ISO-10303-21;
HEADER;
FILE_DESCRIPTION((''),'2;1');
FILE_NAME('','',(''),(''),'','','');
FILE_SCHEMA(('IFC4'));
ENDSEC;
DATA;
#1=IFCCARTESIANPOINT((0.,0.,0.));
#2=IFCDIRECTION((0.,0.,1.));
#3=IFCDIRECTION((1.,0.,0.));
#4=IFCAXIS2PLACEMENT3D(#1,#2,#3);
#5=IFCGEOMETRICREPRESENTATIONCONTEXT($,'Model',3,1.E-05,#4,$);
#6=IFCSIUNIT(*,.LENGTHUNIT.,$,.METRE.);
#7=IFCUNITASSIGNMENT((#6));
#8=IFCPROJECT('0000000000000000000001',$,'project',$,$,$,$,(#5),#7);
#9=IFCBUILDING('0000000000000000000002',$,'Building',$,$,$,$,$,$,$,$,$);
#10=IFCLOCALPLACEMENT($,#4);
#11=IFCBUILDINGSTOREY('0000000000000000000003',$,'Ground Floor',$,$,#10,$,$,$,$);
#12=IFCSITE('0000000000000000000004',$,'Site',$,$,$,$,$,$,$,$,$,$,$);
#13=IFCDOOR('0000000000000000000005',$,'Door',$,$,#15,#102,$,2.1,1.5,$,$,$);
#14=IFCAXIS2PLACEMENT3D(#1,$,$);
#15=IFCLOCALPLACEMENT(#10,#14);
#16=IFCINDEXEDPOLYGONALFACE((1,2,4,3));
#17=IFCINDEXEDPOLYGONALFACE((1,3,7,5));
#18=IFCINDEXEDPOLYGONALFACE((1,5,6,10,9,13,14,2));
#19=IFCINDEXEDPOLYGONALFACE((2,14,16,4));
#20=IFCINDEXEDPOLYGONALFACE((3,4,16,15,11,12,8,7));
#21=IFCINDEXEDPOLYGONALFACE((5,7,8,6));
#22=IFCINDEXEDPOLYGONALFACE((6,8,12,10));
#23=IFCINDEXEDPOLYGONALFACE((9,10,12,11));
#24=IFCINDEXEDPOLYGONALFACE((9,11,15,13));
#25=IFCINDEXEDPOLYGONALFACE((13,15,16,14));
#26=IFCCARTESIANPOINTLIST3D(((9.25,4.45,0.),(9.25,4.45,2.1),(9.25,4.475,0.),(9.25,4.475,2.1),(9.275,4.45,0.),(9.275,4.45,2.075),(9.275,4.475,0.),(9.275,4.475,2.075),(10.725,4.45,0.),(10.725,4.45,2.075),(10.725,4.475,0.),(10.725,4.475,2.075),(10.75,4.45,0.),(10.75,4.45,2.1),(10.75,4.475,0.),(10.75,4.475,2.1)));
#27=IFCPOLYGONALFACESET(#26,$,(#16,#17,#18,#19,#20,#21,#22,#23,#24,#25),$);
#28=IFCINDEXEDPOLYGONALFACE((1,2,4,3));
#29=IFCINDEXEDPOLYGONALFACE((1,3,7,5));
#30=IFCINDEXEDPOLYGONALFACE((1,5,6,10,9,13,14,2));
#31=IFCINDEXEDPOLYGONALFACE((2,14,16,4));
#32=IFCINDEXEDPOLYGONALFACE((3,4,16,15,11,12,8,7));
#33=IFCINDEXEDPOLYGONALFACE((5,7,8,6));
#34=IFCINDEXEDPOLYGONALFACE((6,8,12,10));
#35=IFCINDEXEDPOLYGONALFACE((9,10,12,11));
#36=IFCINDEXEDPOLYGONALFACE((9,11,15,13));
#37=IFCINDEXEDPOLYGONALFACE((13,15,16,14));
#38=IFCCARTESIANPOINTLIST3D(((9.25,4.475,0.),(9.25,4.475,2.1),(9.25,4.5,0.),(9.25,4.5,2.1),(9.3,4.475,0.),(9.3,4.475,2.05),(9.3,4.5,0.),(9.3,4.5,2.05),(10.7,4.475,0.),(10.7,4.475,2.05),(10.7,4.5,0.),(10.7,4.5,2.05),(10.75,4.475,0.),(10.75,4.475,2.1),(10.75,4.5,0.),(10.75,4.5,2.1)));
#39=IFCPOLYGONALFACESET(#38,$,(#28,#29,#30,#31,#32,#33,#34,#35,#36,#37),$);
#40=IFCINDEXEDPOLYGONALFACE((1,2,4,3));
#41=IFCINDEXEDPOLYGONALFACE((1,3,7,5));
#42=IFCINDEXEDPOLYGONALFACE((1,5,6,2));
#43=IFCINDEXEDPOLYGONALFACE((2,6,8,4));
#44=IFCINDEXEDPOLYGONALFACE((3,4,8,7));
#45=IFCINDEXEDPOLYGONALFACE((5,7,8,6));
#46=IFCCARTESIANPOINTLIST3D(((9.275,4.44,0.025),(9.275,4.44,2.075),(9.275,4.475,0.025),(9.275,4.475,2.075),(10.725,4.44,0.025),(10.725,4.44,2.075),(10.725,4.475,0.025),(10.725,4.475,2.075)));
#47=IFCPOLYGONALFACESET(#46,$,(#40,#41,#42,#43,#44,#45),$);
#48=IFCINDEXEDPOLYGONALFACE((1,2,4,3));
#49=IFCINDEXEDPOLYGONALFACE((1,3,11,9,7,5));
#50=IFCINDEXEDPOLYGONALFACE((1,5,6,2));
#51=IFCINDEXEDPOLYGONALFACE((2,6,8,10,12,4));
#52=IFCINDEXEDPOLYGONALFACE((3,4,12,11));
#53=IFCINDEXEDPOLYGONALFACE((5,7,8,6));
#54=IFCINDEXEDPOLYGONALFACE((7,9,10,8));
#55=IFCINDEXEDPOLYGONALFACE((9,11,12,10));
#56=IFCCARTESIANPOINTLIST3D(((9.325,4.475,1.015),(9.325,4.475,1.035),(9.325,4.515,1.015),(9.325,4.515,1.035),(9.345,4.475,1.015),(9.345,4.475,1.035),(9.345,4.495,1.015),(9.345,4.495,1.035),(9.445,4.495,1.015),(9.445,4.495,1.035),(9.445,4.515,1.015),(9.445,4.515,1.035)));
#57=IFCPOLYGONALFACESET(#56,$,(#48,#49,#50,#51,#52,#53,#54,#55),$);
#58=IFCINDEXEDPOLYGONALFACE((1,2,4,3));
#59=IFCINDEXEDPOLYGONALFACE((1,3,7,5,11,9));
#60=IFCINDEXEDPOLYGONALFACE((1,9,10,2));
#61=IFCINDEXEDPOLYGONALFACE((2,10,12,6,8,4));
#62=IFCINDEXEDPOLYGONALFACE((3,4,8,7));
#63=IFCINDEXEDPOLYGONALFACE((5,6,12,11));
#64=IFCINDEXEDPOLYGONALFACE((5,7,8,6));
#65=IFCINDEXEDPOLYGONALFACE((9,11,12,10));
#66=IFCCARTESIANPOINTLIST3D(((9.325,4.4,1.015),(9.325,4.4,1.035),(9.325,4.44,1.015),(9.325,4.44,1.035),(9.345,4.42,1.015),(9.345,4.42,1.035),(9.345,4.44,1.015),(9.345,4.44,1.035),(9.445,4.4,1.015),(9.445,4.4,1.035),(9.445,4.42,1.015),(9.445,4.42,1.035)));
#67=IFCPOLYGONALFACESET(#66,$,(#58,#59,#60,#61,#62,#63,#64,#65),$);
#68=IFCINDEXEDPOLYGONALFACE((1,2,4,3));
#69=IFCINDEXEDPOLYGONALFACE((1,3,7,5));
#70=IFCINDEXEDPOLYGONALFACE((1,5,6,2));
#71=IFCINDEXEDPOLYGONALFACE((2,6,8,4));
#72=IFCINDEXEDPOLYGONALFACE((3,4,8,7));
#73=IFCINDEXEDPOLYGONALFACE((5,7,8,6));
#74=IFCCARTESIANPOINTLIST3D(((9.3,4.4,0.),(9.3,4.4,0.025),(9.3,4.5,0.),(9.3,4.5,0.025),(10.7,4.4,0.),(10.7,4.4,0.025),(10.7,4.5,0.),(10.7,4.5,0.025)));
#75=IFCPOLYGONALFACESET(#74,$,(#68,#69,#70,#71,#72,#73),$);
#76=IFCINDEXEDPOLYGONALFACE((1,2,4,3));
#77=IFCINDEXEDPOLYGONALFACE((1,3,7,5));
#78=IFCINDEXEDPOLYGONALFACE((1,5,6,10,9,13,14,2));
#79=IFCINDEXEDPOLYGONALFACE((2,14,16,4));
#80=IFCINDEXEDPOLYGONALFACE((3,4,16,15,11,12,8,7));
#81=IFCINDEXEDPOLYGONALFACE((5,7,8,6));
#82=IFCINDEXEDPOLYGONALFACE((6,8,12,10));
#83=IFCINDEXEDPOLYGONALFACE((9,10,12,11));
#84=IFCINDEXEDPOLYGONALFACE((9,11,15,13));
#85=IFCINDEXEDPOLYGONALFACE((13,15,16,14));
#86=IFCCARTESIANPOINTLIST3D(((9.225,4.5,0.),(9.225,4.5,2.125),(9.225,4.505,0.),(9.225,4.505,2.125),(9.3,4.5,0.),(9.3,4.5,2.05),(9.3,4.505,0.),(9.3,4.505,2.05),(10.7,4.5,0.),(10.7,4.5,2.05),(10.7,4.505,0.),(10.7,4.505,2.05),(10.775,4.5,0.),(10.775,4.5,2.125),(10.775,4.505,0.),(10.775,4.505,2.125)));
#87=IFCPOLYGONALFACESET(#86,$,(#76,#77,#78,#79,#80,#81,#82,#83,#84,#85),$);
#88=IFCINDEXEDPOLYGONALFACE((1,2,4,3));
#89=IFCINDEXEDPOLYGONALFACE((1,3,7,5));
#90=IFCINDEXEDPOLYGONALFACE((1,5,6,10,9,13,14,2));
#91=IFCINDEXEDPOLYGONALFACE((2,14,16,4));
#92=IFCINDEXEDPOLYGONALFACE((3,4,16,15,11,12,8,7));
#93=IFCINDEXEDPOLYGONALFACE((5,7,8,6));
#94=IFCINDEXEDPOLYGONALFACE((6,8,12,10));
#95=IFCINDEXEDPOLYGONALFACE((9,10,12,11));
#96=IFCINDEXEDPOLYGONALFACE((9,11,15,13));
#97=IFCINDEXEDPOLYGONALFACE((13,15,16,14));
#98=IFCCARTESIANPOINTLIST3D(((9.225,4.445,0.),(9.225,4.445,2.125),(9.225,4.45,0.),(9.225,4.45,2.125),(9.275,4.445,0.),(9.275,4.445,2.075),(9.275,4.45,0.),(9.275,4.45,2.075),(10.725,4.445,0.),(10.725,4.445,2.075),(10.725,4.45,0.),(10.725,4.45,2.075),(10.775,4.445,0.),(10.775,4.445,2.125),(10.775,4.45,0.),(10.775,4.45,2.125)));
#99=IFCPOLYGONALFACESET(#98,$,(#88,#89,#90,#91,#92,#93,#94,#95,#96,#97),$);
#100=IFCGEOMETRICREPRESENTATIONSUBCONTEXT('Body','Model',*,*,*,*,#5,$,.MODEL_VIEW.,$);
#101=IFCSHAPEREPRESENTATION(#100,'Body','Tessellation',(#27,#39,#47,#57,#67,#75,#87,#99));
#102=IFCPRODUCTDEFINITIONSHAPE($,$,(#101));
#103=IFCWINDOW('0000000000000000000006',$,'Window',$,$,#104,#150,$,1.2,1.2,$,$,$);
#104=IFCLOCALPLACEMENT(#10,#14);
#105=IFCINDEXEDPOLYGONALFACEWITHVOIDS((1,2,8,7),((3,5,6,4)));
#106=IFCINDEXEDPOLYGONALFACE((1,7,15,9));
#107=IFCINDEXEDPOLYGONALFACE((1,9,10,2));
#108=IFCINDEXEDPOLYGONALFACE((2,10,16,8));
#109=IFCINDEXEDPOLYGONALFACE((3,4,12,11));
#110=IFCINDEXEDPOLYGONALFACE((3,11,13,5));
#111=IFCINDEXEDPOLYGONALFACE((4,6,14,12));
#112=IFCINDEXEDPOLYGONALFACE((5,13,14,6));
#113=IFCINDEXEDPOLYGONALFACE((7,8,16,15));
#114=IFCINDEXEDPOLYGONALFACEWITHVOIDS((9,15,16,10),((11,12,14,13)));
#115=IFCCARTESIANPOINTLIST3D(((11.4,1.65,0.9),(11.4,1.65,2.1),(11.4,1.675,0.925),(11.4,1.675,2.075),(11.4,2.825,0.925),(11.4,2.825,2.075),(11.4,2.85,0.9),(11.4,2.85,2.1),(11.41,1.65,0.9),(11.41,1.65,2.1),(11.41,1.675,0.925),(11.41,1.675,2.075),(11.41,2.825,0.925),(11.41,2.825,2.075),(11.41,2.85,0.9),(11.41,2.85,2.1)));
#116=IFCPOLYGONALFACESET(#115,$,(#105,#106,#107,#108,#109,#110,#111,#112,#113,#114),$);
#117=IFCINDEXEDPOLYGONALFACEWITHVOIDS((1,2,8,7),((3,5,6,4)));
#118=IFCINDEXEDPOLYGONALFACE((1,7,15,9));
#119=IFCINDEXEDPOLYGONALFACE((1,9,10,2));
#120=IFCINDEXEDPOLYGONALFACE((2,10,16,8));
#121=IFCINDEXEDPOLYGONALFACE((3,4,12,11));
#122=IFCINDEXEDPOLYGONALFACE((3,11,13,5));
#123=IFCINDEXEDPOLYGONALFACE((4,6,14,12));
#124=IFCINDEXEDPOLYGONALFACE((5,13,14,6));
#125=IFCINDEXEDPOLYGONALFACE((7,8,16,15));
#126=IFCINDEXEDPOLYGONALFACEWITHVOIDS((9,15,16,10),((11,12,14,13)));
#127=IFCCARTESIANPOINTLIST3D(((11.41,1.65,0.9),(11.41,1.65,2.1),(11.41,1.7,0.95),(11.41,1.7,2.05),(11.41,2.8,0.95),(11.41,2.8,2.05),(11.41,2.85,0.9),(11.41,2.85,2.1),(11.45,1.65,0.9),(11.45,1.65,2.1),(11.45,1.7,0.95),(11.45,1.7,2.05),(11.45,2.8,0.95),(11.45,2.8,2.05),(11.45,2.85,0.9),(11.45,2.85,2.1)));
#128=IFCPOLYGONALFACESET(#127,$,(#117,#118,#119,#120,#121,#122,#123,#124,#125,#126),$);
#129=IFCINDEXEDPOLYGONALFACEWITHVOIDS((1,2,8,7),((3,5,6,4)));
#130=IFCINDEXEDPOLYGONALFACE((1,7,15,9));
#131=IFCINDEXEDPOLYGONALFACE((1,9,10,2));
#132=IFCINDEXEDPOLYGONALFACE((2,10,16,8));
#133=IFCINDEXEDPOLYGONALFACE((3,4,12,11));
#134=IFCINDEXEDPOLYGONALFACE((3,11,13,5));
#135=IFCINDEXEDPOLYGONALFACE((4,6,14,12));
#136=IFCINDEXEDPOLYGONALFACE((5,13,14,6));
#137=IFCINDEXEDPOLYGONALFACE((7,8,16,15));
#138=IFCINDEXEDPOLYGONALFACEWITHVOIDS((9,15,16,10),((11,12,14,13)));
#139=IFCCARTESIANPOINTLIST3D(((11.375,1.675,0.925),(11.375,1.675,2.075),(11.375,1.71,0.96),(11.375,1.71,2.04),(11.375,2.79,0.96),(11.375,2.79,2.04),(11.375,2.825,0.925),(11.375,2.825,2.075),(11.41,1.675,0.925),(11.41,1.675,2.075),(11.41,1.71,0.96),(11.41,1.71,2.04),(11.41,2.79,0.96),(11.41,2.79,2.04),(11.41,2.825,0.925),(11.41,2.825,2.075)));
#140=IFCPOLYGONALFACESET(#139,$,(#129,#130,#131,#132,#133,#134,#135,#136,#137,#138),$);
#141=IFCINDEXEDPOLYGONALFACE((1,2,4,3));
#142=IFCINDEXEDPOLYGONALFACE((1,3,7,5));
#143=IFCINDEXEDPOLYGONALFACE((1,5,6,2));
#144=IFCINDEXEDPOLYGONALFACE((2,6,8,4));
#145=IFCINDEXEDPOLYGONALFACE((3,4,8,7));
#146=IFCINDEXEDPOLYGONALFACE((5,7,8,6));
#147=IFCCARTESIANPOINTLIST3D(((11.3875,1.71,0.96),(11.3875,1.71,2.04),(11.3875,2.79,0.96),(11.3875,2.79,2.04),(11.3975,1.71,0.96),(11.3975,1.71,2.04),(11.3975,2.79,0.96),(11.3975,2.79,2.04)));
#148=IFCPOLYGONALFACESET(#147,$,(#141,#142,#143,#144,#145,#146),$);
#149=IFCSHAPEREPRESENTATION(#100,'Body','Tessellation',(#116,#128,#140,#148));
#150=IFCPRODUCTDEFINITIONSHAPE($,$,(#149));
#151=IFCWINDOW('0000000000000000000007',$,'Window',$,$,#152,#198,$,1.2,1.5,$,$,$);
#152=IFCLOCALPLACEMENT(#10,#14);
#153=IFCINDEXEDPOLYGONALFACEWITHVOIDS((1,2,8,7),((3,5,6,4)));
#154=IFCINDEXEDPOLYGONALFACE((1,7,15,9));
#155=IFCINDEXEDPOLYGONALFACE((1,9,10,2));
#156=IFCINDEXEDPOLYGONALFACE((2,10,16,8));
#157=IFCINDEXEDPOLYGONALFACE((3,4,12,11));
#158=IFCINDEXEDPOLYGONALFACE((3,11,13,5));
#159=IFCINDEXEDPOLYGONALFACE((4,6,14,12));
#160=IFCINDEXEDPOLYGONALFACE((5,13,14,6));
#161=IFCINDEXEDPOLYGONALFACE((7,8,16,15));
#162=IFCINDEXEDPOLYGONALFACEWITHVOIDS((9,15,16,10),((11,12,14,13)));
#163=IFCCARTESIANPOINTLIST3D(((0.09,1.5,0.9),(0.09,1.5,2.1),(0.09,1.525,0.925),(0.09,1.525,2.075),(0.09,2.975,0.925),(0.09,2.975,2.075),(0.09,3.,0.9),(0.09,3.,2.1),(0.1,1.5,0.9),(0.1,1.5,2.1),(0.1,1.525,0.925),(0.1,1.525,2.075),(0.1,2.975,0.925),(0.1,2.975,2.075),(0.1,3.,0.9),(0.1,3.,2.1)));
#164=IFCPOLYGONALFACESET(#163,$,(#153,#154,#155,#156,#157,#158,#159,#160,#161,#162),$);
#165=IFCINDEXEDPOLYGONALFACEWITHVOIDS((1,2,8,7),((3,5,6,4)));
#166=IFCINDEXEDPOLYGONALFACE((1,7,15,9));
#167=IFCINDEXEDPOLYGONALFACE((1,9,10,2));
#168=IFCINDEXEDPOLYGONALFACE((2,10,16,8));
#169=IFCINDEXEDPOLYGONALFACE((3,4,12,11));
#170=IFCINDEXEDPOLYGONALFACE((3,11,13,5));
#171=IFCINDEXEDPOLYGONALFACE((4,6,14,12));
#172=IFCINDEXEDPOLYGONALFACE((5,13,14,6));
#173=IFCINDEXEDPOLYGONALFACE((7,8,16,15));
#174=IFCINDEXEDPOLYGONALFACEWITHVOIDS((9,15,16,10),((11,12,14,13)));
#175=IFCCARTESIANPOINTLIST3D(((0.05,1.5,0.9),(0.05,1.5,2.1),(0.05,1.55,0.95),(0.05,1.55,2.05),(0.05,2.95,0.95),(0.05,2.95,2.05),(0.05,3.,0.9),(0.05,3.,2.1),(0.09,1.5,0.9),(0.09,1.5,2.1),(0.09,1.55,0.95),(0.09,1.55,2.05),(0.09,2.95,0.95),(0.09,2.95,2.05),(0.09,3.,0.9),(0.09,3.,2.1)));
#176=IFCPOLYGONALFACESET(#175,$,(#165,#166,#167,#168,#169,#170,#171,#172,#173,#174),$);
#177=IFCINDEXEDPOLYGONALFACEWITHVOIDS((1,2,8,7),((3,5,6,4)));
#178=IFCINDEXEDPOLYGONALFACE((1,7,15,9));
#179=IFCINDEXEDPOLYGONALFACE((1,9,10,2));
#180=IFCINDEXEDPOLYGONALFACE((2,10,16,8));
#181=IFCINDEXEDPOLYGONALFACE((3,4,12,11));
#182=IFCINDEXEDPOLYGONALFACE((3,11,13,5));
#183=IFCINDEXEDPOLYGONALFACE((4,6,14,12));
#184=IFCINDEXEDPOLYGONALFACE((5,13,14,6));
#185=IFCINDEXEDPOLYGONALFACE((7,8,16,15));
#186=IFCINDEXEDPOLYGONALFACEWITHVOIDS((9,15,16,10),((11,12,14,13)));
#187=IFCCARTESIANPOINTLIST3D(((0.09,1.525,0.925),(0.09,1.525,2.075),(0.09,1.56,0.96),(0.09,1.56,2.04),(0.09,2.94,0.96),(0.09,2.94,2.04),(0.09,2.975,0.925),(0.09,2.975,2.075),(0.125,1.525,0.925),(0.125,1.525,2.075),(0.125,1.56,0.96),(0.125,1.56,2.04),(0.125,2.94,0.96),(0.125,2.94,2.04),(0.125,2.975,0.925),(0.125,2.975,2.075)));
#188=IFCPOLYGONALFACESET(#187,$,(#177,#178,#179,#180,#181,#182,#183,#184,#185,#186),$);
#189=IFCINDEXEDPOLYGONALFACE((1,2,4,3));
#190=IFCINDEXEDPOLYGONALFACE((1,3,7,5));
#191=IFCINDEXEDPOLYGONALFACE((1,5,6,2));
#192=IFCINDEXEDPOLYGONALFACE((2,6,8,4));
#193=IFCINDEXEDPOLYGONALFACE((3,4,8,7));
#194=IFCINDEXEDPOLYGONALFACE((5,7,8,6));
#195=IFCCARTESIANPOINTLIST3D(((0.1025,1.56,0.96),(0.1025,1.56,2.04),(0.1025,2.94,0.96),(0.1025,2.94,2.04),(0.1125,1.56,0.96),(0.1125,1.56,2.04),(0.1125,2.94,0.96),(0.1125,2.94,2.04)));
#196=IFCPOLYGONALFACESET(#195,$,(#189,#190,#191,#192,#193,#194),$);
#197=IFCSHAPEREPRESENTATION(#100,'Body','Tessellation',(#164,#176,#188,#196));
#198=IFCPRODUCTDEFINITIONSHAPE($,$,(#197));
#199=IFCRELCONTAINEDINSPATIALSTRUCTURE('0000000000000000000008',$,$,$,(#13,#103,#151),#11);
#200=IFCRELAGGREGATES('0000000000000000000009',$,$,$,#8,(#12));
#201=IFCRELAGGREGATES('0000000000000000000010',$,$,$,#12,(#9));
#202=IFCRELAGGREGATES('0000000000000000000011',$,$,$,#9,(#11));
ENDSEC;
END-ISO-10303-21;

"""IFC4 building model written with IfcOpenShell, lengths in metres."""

from ifc_helpers import new_model, si_unit, frame, origin_with_axes, place, context, subcontext, project, spatial, line, indexed_curve, outline, extrude, element, save


model = new_model("IFC4")

# Units and contexts
model_context = context("Model", 3, precision=1e-05, world=origin_with_axes())
body_context = subcontext(model_context, "Body", "Model", "MODEL_VIEW")
ifc_project = project(units=[si_unit("LENGTHUNIT", "METRE")], contexts=[model_context])

# Site, building, storey
site = spatial("IfcSite", under=ifc_project, Name="Site")
building = spatial("IfcBuilding", under=site, Name="Building")
storey_placement = place(None, origin_with_axes())
storey = spatial("IfcBuildingStorey", under=building, at=storey_placement, Name="Ground Floor")

# Door
door_1_placement = place(storey_placement, frame((10.75, 4.5, 0.0), z_axis=(0.0, 0.0, 1.0), x_axis=(-1.0, 0.0, 0.0)))
element("IfcDoor", 1, at=door_1_placement, inside=storey, Name="Door", OverallHeight=2.1, OverallWidth=1.5, context=body_context, shape_type="SweptSolid", body=[
    extrude(outline(indexed_curve([(0.0, 0.0), (0.0, 2.1), (1.5, 2.1), (1.5, 0.0), (1.475, 0.0), (1.475, 2.075), (0.025, 2.075), (0.025, 0.0)], segments=[line(1, 2, 3, 4, 5, 6, 7, 8, 1)])), frame((0.0, 0.025, 0.0), z_axis=(0.0, -1.0, 0.0), x_axis=(1.0, 0.0, 0.0)), (0.0, 0.0, -1.0), 0.025),
    extrude(outline(indexed_curve([(0.0, 0.0), (0.0, 2.1), (1.5, 2.1), (1.5, 0.0), (1.45, 0.0), (1.45, 2.05), (0.05, 2.05), (0.05, 0.0)], segments=[line(1, 2, 3, 4, 5, 6, 7, 8, 1)])), frame((0.0, 0.0, 0.0), z_axis=(0.0, -1.0, 0.0), x_axis=(1.0, 0.0, 0.0)), (0.0, 0.0, -1.0), 0.025),
    extrude(outline(indexed_curve([(0.0, 0.0), (1.45, 0.0), (1.45, 0.035), (0.0, 0.035)], segments=[line(1, 2, 3, 4, 1)])), frame((0.025, 0.025, 0.025), z_axis=(0.0, 0.0, 1.0), x_axis=(1.0, 0.0, 0.0)), (0.0, 0.0, 1.0), 2.05),
    extrude(outline(indexed_curve([(0.0, 0.0), (0.0, -0.04), (-0.12, -0.04), (-0.12, -0.02), (-0.02, -0.02), (-0.02, 0.0)], segments=[line(1, 2, 3, 4, 5, 6, 1)])), frame((1.425, 0.025, 1.015), z_axis=(0.0, 0.0, 1.0), x_axis=(1.0, 0.0, 0.0)), (0.0, 0.0, 1.0), 0.02),
    extrude(outline(indexed_curve([(0.0, 0.0), (0.0, 0.04), (-0.12, 0.04), (-0.12, 0.02), (-0.02, 0.02), (-0.02, 0.0)], segments=[line(1, 2, 3, 4, 5, 6, 1)])), frame((1.425, 0.06, 1.015), z_axis=(0.0, 0.0, 1.0), x_axis=(1.0, 0.0, 0.0)), (0.0, 0.0, 1.0), 0.02),
    extrude(outline(indexed_curve([(0.0, 0.0), (1.4, 0.0), (1.4, 0.1), (0.0, 0.1)], segments=[line(1, 2, 3, 4, 1)])), frame((0.05, 0.0, 0.0), z_axis=(0.0, 0.0, 1.0), x_axis=(1.0, 0.0, 0.0)), (0.0, 0.0, 1.0), 0.025),
    extrude(outline(indexed_curve([(0.0, 0.0), (0.0, 2.125), (1.55, 2.125), (1.55, 0.0), (1.475, 0.0), (1.475, 2.05), (0.075, 2.05), (0.075, 0.0)], segments=[line(1, 2, 3, 4, 5, 6, 7, 8, 1)])), frame((-0.025, -0.005, 0.0), z_axis=(0.0, -1.0, 0.0), x_axis=(1.0, 0.0, 0.0)), (0.0, 0.0, -1.0), 0.005),
    extrude(outline(indexed_curve([(0.0, 0.0), (0.0, 2.125), (1.55, 2.125), (1.55, 0.0), (1.5, 0.0), (1.5, 2.075), (0.05, 2.075), (0.05, 0.0)], segments=[line(1, 2, 3, 4, 5, 6, 7, 8, 1)])), frame((-0.025, 0.05, 0.0), z_axis=(0.0, -1.0, 0.0), x_axis=(1.0, 0.0, 0.0)), (0.0, 0.0, -1.0), 0.005),
])

# Windows
window_1_placement = place(storey_placement, frame((11.5, 1.65, 0.9), z_axis=(0.0, 0.0, 1.0), x_axis=(0.0, 1.0, 0.0)))
element("IfcWindow", 2, at=window_1_placement, inside=storey, Name="Window", OverallHeight=1.2, OverallWidth=1.2, context=body_context, shape_type="SweptSolid", body=[
    extrude(outline(indexed_curve([(0.0, 0.0), (1.2, 0.0), (1.2, 1.2), (0.0, 1.2)], segments=[line(1, 2, 3, 4, 1)]), holes=[indexed_curve([(0.025, 0.025), (1.175, 0.025), (1.175, 1.175), (0.025, 1.175)], segments=[line(1, 2, 3, 4, 1)])]), frame((0.0, 0.09, 0.0), z_axis=(0.0, -1.0, 0.0), x_axis=(1.0, 0.0, 0.0)), (0.0, 0.0, -1.0), 0.01),
    extrude(outline(indexed_curve([(0.0, 0.0), (1.2, 0.0), (1.2, 1.2), (0.0, 1.2)], segments=[line(1, 2, 3, 4, 1)]), holes=[indexed_curve([(0.05, 0.05), (1.15, 0.05), (1.15, 1.15), (0.05, 1.15)], segments=[line(1, 2, 3, 4, 1)])]), frame((0.0, 0.05, 0.0), z_axis=(0.0, -1.0, 0.0), x_axis=(1.0, 0.0, 0.0)), (0.0, 0.0, -1.0), 0.04),
    extrude(outline(indexed_curve([(0.0, 0.0), (1.15, 0.0), (1.15, 1.15), (0.0, 1.15)], segments=[line(1, 2, 3, 4, 1)]), holes=[indexed_curve([(0.035, 0.035), (1.115, 0.035), (1.115, 1.115), (0.035, 1.115)], segments=[line(1, 2, 3, 4, 1)])]), frame((0.025, 0.09, 0.025), z_axis=(0.0, -1.0, 0.0), x_axis=(1.0, 0.0, 0.0)), (0.0, 0.0, -1.0), 0.035),
    extrude(outline(indexed_curve([(0.035, 0.035), (1.115, 0.035), (1.115, 1.115), (0.035, 1.115)], segments=[line(1, 2, 3, 4, 1)])), frame((0.025, 0.1025, 0.025), z_axis=(0.0, -1.0, 0.0), x_axis=(1.0, 0.0, 0.0)), (0.0, 0.0, -1.0), 0.01),
])
for number, where, z_axis, x_axis, name in (
    (3, (0.0, 3.0, 0.9), (0.0, 0.0, 1.0), (0.0, -1.0, 0.0), "Window"),
):
    element("IfcWindow", number, at=place(storey_placement, frame(where, z_axis=z_axis, x_axis=x_axis)), inside=storey, Name=name, OverallHeight=1.2, OverallWidth=1.5, context=body_context, shape_type="SweptSolid", body=[
        extrude(outline(indexed_curve([(0.0, 0.0), (1.5, 0.0), (1.5, 1.2), (0.0, 1.2)], segments=[line(1, 2, 3, 4, 1)]), holes=[indexed_curve([(0.025, 0.025), (1.475, 0.025), (1.475, 1.175), (0.025, 1.175)], segments=[line(1, 2, 3, 4, 1)])]), frame((0.0, 0.09, 0.0), z_axis=(0.0, -1.0, 0.0), x_axis=(1.0, 0.0, 0.0)), (0.0, 0.0, -1.0), 0.01),
        extrude(outline(indexed_curve([(0.0, 0.0), (1.5, 0.0), (1.5, 1.2), (0.0, 1.2)], segments=[line(1, 2, 3, 4, 1)]), holes=[indexed_curve([(0.05, 0.05), (1.45, 0.05), (1.45, 1.15), (0.05, 1.15)], segments=[line(1, 2, 3, 4, 1)])]), frame((0.0, 0.05, 0.0), z_axis=(0.0, -1.0, 0.0), x_axis=(1.0, 0.0, 0.0)), (0.0, 0.0, -1.0), 0.04),
        extrude(outline(indexed_curve([(0.0, 0.0), (1.45, 0.0), (1.45, 1.15), (0.0, 1.15)], segments=[line(1, 2, 3, 4, 1)]), holes=[indexed_curve([(0.035, 0.035), (1.415, 0.035), (1.415, 1.115), (0.035, 1.115)], segments=[line(1, 2, 3, 4, 1)])]), frame((0.025, 0.09, 0.025), z_axis=(0.0, -1.0, 0.0), x_axis=(1.0, 0.0, 0.0)), (0.0, 0.0, -1.0), 0.035),
        extrude(outline(indexed_curve([(0.035, 0.035), (1.415, 0.035), (1.415, 1.115), (0.035, 1.115)], segments=[line(1, 2, 3, 4, 1)])), frame((0.025, 0.1025, 0.025), z_axis=(0.0, -1.0, 0.0), x_axis=(1.0, 0.0, 0.0)), (0.0, 0.0, -1.0), 0.01),
    ])

save(model, "model.ifc")
